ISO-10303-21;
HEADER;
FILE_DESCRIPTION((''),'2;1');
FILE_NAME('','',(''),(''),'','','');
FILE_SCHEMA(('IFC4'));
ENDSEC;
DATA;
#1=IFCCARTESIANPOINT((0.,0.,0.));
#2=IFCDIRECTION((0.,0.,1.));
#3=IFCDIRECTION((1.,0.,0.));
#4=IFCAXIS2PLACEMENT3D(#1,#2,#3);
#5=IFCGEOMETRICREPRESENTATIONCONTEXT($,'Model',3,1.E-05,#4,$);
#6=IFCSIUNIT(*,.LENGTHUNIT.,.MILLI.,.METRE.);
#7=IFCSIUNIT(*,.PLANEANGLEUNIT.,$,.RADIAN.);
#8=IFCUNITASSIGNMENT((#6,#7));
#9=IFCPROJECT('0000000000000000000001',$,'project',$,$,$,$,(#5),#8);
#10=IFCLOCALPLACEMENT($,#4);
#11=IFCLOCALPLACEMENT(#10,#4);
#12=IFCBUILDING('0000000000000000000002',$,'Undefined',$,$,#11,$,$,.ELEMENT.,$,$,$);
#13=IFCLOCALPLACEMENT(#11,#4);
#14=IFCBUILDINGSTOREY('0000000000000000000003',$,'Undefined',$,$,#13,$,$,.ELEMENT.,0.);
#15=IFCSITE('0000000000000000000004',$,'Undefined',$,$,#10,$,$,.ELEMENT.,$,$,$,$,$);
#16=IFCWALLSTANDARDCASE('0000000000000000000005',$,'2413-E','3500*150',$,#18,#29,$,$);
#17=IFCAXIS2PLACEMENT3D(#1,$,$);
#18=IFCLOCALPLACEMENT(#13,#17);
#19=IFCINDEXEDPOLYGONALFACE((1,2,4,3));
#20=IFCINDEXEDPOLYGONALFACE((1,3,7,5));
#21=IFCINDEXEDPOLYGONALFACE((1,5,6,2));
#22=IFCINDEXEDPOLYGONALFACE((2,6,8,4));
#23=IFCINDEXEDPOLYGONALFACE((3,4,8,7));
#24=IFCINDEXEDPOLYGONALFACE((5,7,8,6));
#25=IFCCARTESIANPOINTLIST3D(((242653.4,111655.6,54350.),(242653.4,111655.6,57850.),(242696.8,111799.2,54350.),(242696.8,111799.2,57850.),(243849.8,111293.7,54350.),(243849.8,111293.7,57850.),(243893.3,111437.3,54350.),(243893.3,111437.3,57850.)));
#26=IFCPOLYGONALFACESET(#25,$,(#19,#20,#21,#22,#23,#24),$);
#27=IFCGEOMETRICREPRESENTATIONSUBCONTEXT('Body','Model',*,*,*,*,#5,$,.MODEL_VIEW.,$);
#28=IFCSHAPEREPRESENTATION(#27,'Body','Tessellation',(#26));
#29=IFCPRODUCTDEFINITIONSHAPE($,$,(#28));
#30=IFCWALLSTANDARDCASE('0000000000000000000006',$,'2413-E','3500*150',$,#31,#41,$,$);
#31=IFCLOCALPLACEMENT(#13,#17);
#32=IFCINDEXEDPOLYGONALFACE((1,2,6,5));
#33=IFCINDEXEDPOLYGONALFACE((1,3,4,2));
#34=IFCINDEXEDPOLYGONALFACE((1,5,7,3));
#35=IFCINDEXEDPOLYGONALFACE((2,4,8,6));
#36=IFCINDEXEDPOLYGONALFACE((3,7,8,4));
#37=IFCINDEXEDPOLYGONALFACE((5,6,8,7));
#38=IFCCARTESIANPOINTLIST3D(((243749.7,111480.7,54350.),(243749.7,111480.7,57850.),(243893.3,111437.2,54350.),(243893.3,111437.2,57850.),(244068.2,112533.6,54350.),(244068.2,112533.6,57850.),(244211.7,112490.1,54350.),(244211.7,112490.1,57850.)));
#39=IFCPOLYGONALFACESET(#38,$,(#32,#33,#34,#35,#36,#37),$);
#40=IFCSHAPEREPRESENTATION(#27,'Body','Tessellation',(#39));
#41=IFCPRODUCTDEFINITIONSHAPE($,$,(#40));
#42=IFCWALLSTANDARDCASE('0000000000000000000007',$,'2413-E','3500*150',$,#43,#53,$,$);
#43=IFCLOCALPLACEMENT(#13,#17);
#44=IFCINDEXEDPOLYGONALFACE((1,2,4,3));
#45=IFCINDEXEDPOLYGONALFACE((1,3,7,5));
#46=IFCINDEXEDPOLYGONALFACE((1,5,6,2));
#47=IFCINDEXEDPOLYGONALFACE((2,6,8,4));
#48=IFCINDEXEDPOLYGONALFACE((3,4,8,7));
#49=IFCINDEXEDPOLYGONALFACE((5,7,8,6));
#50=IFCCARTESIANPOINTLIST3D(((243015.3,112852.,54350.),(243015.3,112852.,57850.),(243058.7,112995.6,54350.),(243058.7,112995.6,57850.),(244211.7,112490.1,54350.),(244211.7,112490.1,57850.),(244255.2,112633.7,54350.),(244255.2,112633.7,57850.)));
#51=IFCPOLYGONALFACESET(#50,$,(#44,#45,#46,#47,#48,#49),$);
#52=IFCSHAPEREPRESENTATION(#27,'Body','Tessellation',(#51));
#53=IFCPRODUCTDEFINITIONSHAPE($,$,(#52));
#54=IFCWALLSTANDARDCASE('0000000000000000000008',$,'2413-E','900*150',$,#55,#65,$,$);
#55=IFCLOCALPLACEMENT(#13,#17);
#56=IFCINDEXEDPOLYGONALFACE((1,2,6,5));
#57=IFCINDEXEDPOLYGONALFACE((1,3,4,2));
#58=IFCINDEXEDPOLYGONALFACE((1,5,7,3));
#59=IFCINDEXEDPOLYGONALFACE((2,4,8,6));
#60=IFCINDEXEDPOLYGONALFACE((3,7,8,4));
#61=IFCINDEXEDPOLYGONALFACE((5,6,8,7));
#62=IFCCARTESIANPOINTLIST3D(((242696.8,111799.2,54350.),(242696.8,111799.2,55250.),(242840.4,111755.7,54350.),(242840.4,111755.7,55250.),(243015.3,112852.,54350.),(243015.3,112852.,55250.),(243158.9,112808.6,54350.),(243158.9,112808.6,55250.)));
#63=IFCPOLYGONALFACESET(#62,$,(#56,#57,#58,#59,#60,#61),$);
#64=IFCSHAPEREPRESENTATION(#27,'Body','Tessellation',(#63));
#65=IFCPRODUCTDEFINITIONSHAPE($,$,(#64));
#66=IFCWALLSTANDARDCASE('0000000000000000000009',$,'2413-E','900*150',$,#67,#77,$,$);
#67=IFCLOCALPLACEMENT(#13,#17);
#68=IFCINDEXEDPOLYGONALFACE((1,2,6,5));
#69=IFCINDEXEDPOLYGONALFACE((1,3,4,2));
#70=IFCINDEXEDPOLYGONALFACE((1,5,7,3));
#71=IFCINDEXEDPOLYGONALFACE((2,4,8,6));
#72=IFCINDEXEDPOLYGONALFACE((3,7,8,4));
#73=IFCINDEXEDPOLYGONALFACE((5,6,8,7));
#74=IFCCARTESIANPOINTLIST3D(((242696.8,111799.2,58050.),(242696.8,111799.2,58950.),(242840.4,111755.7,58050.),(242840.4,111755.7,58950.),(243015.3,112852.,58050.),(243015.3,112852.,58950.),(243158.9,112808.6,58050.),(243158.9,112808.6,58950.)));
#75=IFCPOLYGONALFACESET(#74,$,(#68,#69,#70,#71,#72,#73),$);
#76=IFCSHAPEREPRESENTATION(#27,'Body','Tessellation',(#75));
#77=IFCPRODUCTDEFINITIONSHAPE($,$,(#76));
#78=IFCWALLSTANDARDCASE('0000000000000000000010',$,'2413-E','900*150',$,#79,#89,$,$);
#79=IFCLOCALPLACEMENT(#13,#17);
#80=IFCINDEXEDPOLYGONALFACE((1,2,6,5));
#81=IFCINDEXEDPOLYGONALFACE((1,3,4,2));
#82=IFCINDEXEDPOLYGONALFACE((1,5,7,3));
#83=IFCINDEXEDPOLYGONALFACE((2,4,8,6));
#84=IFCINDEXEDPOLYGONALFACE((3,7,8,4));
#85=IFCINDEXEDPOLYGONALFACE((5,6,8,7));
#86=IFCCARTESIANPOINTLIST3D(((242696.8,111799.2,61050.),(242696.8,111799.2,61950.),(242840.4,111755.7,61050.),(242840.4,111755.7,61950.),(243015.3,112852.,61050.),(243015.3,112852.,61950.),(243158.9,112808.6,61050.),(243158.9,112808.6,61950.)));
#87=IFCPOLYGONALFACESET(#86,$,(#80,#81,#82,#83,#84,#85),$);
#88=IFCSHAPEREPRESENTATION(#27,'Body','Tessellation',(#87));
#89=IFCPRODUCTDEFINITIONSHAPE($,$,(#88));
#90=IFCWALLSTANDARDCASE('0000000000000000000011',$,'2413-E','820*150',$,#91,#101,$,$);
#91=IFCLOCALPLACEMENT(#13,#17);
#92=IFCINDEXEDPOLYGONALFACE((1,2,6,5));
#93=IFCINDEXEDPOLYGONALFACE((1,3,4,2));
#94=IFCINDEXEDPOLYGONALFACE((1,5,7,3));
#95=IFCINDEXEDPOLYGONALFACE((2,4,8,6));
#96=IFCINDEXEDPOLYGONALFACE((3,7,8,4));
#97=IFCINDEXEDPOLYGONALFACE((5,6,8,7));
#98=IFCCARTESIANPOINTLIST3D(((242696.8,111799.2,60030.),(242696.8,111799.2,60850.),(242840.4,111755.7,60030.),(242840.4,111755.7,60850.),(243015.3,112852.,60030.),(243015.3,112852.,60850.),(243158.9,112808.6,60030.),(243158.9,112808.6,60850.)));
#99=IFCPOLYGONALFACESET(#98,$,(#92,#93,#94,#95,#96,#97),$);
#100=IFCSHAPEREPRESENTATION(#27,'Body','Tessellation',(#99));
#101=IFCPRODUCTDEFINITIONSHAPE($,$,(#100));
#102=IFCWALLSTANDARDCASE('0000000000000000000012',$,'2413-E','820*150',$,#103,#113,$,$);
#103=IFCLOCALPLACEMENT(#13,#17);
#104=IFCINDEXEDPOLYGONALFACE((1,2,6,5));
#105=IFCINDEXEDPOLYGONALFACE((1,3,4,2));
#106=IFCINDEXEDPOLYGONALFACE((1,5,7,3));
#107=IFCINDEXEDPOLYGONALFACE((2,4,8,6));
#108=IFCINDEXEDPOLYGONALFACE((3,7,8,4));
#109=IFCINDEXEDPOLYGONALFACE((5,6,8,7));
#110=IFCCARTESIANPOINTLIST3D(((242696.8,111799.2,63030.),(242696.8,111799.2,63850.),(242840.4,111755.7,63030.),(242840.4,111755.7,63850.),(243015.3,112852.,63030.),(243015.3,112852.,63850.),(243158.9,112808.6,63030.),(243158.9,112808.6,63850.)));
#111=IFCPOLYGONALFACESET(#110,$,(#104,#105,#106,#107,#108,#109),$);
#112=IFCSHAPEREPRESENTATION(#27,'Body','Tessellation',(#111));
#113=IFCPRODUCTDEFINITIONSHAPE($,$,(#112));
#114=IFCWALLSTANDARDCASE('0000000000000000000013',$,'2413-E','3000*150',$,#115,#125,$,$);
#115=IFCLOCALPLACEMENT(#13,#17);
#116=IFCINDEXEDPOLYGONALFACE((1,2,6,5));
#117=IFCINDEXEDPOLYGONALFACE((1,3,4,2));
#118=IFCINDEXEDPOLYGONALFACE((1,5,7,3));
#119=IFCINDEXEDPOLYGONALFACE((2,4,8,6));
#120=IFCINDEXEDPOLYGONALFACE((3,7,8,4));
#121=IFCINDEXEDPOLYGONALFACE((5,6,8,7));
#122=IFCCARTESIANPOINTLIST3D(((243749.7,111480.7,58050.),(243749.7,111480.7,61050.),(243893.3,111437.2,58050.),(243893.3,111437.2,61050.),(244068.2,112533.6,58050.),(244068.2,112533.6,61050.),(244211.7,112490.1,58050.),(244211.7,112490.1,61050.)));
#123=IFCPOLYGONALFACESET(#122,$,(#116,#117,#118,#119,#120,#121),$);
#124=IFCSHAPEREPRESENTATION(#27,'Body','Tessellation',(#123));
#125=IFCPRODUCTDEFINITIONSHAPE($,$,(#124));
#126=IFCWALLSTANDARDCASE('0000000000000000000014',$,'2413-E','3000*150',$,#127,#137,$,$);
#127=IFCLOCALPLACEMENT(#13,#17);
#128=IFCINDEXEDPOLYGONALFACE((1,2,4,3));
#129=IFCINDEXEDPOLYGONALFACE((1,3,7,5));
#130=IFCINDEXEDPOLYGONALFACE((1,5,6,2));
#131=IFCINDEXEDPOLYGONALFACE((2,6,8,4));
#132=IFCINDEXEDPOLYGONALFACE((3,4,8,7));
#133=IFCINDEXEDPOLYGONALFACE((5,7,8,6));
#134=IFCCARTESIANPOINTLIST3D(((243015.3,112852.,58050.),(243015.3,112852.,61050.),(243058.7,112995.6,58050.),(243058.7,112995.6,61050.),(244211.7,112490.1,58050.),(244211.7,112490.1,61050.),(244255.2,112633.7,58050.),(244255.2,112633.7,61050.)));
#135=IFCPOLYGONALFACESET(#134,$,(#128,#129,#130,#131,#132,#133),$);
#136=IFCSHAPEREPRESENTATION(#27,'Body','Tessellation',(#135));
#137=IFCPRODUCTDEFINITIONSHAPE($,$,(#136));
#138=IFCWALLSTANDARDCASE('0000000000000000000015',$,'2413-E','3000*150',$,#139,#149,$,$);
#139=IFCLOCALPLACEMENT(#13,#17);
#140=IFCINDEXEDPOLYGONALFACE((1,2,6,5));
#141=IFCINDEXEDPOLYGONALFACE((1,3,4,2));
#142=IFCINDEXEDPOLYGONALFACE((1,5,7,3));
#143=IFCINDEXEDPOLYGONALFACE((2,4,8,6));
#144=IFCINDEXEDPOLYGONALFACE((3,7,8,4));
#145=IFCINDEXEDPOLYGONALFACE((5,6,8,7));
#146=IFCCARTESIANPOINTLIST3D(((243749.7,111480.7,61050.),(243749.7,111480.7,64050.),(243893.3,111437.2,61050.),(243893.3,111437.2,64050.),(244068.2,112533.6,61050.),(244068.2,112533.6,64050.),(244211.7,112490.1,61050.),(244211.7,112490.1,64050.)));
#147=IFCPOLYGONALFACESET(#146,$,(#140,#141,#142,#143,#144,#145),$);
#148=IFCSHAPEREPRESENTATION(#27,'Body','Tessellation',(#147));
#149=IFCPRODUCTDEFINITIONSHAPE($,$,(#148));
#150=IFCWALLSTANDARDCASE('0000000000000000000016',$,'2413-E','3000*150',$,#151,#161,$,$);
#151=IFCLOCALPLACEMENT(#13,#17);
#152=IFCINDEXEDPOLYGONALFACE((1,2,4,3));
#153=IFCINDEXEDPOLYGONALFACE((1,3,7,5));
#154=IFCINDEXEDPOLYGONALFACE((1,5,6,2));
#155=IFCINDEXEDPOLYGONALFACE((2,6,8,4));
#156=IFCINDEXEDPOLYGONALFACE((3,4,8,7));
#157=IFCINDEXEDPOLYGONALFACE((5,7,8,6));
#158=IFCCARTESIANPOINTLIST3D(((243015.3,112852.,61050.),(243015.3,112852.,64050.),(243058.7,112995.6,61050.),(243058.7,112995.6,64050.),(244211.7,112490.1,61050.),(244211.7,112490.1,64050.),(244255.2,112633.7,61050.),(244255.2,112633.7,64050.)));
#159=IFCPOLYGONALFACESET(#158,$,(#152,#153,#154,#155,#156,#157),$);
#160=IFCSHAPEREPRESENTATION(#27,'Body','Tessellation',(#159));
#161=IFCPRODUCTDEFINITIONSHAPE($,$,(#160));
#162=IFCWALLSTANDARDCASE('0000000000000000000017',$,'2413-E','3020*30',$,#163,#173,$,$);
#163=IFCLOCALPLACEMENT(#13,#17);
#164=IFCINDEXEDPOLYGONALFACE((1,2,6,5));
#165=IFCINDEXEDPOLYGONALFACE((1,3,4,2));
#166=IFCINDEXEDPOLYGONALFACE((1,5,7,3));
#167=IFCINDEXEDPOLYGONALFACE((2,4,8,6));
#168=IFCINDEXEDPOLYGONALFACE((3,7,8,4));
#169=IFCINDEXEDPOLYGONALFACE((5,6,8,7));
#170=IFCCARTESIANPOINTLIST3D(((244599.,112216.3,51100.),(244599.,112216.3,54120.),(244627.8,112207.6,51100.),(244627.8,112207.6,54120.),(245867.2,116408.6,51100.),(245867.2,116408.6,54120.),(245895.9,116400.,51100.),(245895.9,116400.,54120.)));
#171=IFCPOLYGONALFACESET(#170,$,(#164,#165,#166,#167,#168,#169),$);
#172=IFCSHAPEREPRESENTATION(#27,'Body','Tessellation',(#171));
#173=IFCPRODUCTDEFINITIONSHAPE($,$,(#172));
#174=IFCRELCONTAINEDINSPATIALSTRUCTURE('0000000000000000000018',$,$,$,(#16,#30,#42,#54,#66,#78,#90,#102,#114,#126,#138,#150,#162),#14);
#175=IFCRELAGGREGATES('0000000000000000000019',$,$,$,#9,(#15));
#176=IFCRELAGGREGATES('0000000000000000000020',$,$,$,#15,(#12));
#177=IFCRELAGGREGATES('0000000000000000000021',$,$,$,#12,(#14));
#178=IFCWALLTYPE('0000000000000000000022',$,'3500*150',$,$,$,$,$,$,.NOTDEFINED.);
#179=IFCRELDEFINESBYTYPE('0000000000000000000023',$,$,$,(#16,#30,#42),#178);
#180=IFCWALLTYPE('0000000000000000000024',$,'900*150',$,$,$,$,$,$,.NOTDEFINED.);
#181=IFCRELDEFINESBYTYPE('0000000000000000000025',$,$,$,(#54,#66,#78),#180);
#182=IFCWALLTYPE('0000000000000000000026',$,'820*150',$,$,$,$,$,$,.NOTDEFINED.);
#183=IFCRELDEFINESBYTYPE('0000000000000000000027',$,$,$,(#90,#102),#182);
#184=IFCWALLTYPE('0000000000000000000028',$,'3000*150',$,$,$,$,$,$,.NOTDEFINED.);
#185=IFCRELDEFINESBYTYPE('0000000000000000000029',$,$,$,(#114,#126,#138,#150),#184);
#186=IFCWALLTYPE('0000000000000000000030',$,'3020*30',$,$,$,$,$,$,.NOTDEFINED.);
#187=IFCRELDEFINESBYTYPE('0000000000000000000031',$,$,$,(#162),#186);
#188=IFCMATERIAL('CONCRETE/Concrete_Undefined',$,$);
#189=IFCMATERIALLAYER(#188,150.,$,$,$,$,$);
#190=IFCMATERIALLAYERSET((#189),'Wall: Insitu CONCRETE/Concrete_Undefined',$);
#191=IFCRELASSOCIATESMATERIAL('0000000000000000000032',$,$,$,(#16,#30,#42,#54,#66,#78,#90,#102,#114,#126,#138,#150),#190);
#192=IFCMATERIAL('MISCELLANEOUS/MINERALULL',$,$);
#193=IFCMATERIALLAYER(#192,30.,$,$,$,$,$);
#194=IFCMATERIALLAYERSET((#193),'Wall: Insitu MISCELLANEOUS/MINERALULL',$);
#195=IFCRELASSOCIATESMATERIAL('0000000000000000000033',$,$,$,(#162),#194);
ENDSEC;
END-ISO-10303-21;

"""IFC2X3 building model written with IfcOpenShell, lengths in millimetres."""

from ifc_helpers import new_model, si_unit, frame, frame_2d, origin_with_axes, place, context, subcontext, project, spatial, rectangle, extrude, material, layer, layer_set, layer_usage, type_object, element, save


model = new_model("IFC2X3")

# Units and contexts
model_context = context("Model", 3, precision=1e-05, world=origin_with_axes())
body_context = subcontext(model_context, "Body", "Model", "MODEL_VIEW")
ifc_project = project(units=[si_unit("LENGTHUNIT", "METRE", prefix="MILLI"), si_unit("PLANEANGLEUNIT", "RADIAN")], contexts=[model_context])

# Site, building, storey
site_placement = place(None, origin_with_axes())
site = spatial("IfcSite", under=ifc_project, at=site_placement, Name="Undefined", CompositionType="ELEMENT")
building_placement = place(site_placement, origin_with_axes())
building = spatial("IfcBuilding", under=site, at=building_placement, Name="Undefined", CompositionType="ELEMENT")
storey_placement = place(building_placement, origin_with_axes())
storey = spatial("IfcBuildingStorey", under=building, at=storey_placement, Name="Undefined", CompositionType="ELEMENT", Elevation=0.0)

# Walls
ifc_material_1 = material(Name="CONCRETE/Concrete_Undefined")
ifc_layer_1 = layer(ifc_material_1, 150.0)
ifc_layer_set_1 = layer_set([ifc_layer_1], Name="Wall: Insitu CONCRETE/Concrete_Undefined")
ifc_layer_usage_1 = layer_usage(ifc_layer_set_1, "AXIS2", "POSITIVE", -75.0)
wall_type_1 = type_object("IfcWallType", Name="3500*150", PredefinedType="NOTDEFINED")
wall_1_placement = place(storey_placement, frame((242675.1, 111727.4, 54350.0), z_axis=(0.0, 0.0, 1.0), x_axis=(0.957168, -0.289532, 0.0)))
element("IfcWallStandardCase", 1, at=wall_1_placement, inside=storey, type_object=wall_type_1, material=ifc_layer_usage_1, Name="2413-E", Description="3500*150", context=body_context, shape_type="SweptSolid", body=[
    extrude(rectangle(XDim=1250.0, YDim=150.0, at=frame_2d((0.0, 625.0), x_axis=(0.0, -1.0))), frame((0.0, 0.0, 0.0), z_axis=(0.0, 0.0, 1.0), x_axis=(0.0, -1.0, 0.0)), (0.0, 0.0, 1.0), 3500.0),
])
ifc_layer_usage_2 = layer_usage(ifc_layer_set_1, "AXIS2", "POSITIVE", -75.0)
wall_2_placement = place(storey_placement, frame((244140.0, 112511.8, 54350.0), z_axis=(0.0, 0.0, 1.0), x_axis=(-0.289534, -0.957168, 0.0)))
element("IfcWallStandardCase", 2, at=wall_2_placement, inside=storey, type_object=wall_type_1, material=ifc_layer_usage_2, Name="2413-E", Description="3500*150", context=body_context, shape_type="SweptSolid", body=[
    extrude(rectangle(XDim=1100.0, YDim=150.0, at=frame_2d((0.0, 550.0), x_axis=(0.0, -1.0))), frame((0.0, 0.0, 0.0), z_axis=(0.0, 0.0, 1.0), x_axis=(0.0, -1.0, 0.0)), (0.0, 0.0, 1.0), 3500.0),
])
ifc_layer_usage_3 = layer_usage(ifc_layer_set_1, "AXIS2", "POSITIVE", -75.0)
wall_3_placement = place(storey_placement, frame((243037.0, 112923.8, 54350.0), z_axis=(0.0, 0.0, 1.0), x_axis=(0.957168, -0.289532, 0.0)))
element("IfcWallStandardCase", 3, at=wall_3_placement, inside=storey, type_object=wall_type_1, material=ifc_layer_usage_3, Name="2413-E", Description="3500*150", context=body_context, shape_type="SweptSolid", body=[
    extrude(rectangle(XDim=1250.0, YDim=150.0, at=frame_2d((0.0, 625.0), x_axis=(0.0, -1.0))), frame((0.0, 0.0, 0.0), z_axis=(0.0, 0.0, 1.0), x_axis=(0.0, -1.0, 0.0)), (0.0, 0.0, 1.0), 3500.0),
])
ifc_layer_usage_4 = layer_usage(ifc_layer_set_1, "AXIS2", "POSITIVE", -75.0)
wall_type_2 = type_object("IfcWallType", Name="900*150", PredefinedType="NOTDEFINED")
wall_4_placement = place(storey_placement, frame((242768.6, 111777.4, 54350.0), z_axis=(0.0, 0.0, 1.0), x_axis=(0.289534, 0.957168, 0.0)))
element("IfcWallStandardCase", 4, at=wall_4_placement, inside=storey, type_object=wall_type_2, material=ifc_layer_usage_4, Name="2413-E", Description="900*150", context=body_context, shape_type="SweptSolid", body=[
    extrude(rectangle(XDim=1100.0, YDim=150.0, at=frame_2d((0.0, 550.0), x_axis=(0.0, -1.0))), frame((0.0, 0.0, 0.0), z_axis=(0.0, 0.0, 1.0), x_axis=(0.0, -1.0, 0.0)), (0.0, 0.0, 1.0), 900.0),
])
ifc_layer_usage_5 = layer_usage(ifc_layer_set_1, "AXIS2", "POSITIVE", -75.0)
wall_5_placement = place(storey_placement, frame((242768.6, 111777.4, 58050.0), z_axis=(0.0, 0.0, 1.0), x_axis=(0.289534, 0.957168, 0.0)))
element("IfcWallStandardCase", 5, at=wall_5_placement, inside=storey, type_object=wall_type_2, material=ifc_layer_usage_5, Name="2413-E", Description="900*150", context=body_context, shape_type="SweptSolid", body=[
    extrude(rectangle(XDim=1100.0, YDim=150.0, at=frame_2d((0.0, 550.0), x_axis=(0.0, -1.0))), frame((0.0, 0.0, 0.0), z_axis=(0.0, 0.0, 1.0), x_axis=(0.0, -1.0, 0.0)), (0.0, 0.0, 1.0), 900.0),
])
ifc_layer_usage_6 = layer_usage(ifc_layer_set_1, "AXIS2", "POSITIVE", -75.0)
wall_6_placement = place(storey_placement, frame((242768.6, 111777.4, 61050.0), z_axis=(0.0, 0.0, 1.0), x_axis=(0.289534, 0.957168, 0.0)))
element("IfcWallStandardCase", 6, at=wall_6_placement, inside=storey, type_object=wall_type_2, material=ifc_layer_usage_6, Name="2413-E", Description="900*150", context=body_context, shape_type="SweptSolid", body=[
    extrude(rectangle(XDim=1100.0, YDim=150.0, at=frame_2d((0.0, 550.0), x_axis=(0.0, -1.0))), frame((0.0, 0.0, 0.0), z_axis=(0.0, 0.0, 1.0), x_axis=(0.0, -1.0, 0.0)), (0.0, 0.0, 1.0), 900.0),
])
ifc_layer_usage_7 = layer_usage(ifc_layer_set_1, "AXIS2", "POSITIVE", -75.0)
wall_type_3 = type_object("IfcWallType", Name="820*150", PredefinedType="NOTDEFINED")
wall_7_placement = place(storey_placement, frame((242768.6, 111777.4, 60030.0), z_axis=(0.0, 0.0, 1.0), x_axis=(0.289534, 0.957168, 0.0)))
element("IfcWallStandardCase", 7, at=wall_7_placement, inside=storey, type_object=wall_type_3, material=ifc_layer_usage_7, Name="2413-E", Description="820*150", context=body_context, shape_type="SweptSolid", body=[
    extrude(rectangle(XDim=1100.0, YDim=150.0, at=frame_2d((0.0, 550.0), x_axis=(0.0, -1.0))), frame((0.0, 0.0, 0.0), z_axis=(0.0, 0.0, 1.0), x_axis=(0.0, -1.0, 0.0)), (0.0, 0.0, 1.0), 820.0),
])
ifc_layer_usage_8 = layer_usage(ifc_layer_set_1, "AXIS2", "POSITIVE", -75.0)
wall_8_placement = place(storey_placement, frame((242768.6, 111777.4, 63030.0), z_axis=(0.0, 0.0, 1.0), x_axis=(0.289534, 0.957168, 0.0)))
element("IfcWallStandardCase", 8, at=wall_8_placement, inside=storey, type_object=wall_type_3, material=ifc_layer_usage_8, Name="2413-E", Description="820*150", context=body_context, shape_type="SweptSolid", body=[
    extrude(rectangle(XDim=1100.0, YDim=150.0, at=frame_2d((0.0, 550.0), x_axis=(0.0, -1.0))), frame((0.0, 0.0, 0.0), z_axis=(0.0, 0.0, 1.0), x_axis=(0.0, -1.0, 0.0)), (0.0, 0.0, 1.0), 820.0),
])
ifc_layer_usage_9 = layer_usage(ifc_layer_set_1, "AXIS2", "POSITIVE", -75.0)
wall_type_4 = type_object("IfcWallType", Name="3000*150", PredefinedType="NOTDEFINED")
wall_9_placement = place(storey_placement, frame((244140.0, 112511.8, 58050.0), z_axis=(0.0, 0.0, 1.0), x_axis=(-0.289534, -0.957168, 0.0)))
element("IfcWallStandardCase", 9, at=wall_9_placement, inside=storey, type_object=wall_type_4, material=ifc_layer_usage_9, Name="2413-E", Description="3000*150", context=body_context, shape_type="SweptSolid", body=[
    extrude(rectangle(XDim=1100.0, YDim=150.0, at=frame_2d((0.0, 550.0), x_axis=(0.0, -1.0))), frame((0.0, 0.0, 0.0), z_axis=(0.0, 0.0, 1.0), x_axis=(0.0, -1.0, 0.0)), (0.0, 0.0, 1.0), 3000.0),
])
ifc_layer_usage_10 = layer_usage(ifc_layer_set_1, "AXIS2", "POSITIVE", -75.0)
wall_10_placement = place(storey_placement, frame((243037.0, 112923.8, 58050.0), z_axis=(0.0, 0.0, 1.0), x_axis=(0.957168, -0.289532, 0.0)))
element("IfcWallStandardCase", 10, at=wall_10_placement, inside=storey, type_object=wall_type_4, material=ifc_layer_usage_10, Name="2413-E", Description="3000*150", context=body_context, shape_type="SweptSolid", body=[
    extrude(rectangle(XDim=1250.0, YDim=150.0, at=frame_2d((0.0, 625.0), x_axis=(0.0, -1.0))), frame((0.0, 0.0, 0.0), z_axis=(0.0, 0.0, 1.0), x_axis=(0.0, -1.0, 0.0)), (0.0, 0.0, 1.0), 3000.0),
])
ifc_layer_usage_11 = layer_usage(ifc_layer_set_1, "AXIS2", "POSITIVE", -75.0)
wall_11_placement = place(storey_placement, frame((244140.0, 112511.8, 61050.0), z_axis=(0.0, 0.0, 1.0), x_axis=(-0.289534, -0.957168, 0.0)))
element("IfcWallStandardCase", 11, at=wall_11_placement, inside=storey, type_object=wall_type_4, material=ifc_layer_usage_11, Name="2413-E", Description="3000*150", context=body_context, shape_type="SweptSolid", body=[
    extrude(rectangle(XDim=1100.0, YDim=150.0, at=frame_2d((0.0, 550.0), x_axis=(0.0, -1.0))), frame((0.0, 0.0, 0.0), z_axis=(0.0, 0.0, 1.0), x_axis=(0.0, -1.0, 0.0)), (0.0, 0.0, 1.0), 3000.0),
])
ifc_layer_usage_12 = layer_usage(ifc_layer_set_1, "AXIS2", "POSITIVE", -75.0)
wall_12_placement = place(storey_placement, frame((243037.0, 112923.8, 61050.0), z_axis=(0.0, 0.0, 1.0), x_axis=(0.957168, -0.289532, 0.0)))
element("IfcWallStandardCase", 12, at=wall_12_placement, inside=storey, type_object=wall_type_4, material=ifc_layer_usage_12, Name="2413-E", Description="3000*150", context=body_context, shape_type="SweptSolid", body=[
    extrude(rectangle(XDim=1250.0, YDim=150.0, at=frame_2d((0.0, 625.0), x_axis=(0.0, -1.0))), frame((0.0, 0.0, 0.0), z_axis=(0.0, 0.0, 1.0), x_axis=(0.0, -1.0, 0.0)), (0.0, 0.0, 1.0), 3000.0),
])
ifc_material_2 = material(Name="MISCELLANEOUS/MINERALULL")
ifc_layer_2 = layer(ifc_material_2, 30.0)
ifc_layer_set_2 = layer_set([ifc_layer_2], Name="Wall: Insitu MISCELLANEOUS/MINERALULL")
ifc_layer_usage_13 = layer_usage(ifc_layer_set_2, "AXIS2", "POSITIVE", -15.0)
wall_type_5 = type_object("IfcWallType", Name="3020*30", PredefinedType="NOTDEFINED")
wall_13_placement = place(storey_placement, frame((244613.4, 112211.9, 51100.0), z_axis=(0.0, 0.0, 1.0), x_axis=(0.289537, 0.957167, 0.0)))
element("IfcWallStandardCase", 13, at=wall_13_placement, inside=storey, type_object=wall_type_5, material=ifc_layer_usage_13, Name="2413-E", Description="3020*30", context=body_context, shape_type="SweptSolid", body=[
    extrude(rectangle(XDim=4380.0, YDim=30.0, at=frame_2d((0.0, 2190.0), x_axis=(0.0, -1.0))), frame((0.0, 0.0, 0.0), z_axis=(0.0, 0.0, 1.0), x_axis=(0.0, -1.0, 0.0)), (0.0, 0.0, 1.0), 3020.0),
])

save(model, "model.ifc")
